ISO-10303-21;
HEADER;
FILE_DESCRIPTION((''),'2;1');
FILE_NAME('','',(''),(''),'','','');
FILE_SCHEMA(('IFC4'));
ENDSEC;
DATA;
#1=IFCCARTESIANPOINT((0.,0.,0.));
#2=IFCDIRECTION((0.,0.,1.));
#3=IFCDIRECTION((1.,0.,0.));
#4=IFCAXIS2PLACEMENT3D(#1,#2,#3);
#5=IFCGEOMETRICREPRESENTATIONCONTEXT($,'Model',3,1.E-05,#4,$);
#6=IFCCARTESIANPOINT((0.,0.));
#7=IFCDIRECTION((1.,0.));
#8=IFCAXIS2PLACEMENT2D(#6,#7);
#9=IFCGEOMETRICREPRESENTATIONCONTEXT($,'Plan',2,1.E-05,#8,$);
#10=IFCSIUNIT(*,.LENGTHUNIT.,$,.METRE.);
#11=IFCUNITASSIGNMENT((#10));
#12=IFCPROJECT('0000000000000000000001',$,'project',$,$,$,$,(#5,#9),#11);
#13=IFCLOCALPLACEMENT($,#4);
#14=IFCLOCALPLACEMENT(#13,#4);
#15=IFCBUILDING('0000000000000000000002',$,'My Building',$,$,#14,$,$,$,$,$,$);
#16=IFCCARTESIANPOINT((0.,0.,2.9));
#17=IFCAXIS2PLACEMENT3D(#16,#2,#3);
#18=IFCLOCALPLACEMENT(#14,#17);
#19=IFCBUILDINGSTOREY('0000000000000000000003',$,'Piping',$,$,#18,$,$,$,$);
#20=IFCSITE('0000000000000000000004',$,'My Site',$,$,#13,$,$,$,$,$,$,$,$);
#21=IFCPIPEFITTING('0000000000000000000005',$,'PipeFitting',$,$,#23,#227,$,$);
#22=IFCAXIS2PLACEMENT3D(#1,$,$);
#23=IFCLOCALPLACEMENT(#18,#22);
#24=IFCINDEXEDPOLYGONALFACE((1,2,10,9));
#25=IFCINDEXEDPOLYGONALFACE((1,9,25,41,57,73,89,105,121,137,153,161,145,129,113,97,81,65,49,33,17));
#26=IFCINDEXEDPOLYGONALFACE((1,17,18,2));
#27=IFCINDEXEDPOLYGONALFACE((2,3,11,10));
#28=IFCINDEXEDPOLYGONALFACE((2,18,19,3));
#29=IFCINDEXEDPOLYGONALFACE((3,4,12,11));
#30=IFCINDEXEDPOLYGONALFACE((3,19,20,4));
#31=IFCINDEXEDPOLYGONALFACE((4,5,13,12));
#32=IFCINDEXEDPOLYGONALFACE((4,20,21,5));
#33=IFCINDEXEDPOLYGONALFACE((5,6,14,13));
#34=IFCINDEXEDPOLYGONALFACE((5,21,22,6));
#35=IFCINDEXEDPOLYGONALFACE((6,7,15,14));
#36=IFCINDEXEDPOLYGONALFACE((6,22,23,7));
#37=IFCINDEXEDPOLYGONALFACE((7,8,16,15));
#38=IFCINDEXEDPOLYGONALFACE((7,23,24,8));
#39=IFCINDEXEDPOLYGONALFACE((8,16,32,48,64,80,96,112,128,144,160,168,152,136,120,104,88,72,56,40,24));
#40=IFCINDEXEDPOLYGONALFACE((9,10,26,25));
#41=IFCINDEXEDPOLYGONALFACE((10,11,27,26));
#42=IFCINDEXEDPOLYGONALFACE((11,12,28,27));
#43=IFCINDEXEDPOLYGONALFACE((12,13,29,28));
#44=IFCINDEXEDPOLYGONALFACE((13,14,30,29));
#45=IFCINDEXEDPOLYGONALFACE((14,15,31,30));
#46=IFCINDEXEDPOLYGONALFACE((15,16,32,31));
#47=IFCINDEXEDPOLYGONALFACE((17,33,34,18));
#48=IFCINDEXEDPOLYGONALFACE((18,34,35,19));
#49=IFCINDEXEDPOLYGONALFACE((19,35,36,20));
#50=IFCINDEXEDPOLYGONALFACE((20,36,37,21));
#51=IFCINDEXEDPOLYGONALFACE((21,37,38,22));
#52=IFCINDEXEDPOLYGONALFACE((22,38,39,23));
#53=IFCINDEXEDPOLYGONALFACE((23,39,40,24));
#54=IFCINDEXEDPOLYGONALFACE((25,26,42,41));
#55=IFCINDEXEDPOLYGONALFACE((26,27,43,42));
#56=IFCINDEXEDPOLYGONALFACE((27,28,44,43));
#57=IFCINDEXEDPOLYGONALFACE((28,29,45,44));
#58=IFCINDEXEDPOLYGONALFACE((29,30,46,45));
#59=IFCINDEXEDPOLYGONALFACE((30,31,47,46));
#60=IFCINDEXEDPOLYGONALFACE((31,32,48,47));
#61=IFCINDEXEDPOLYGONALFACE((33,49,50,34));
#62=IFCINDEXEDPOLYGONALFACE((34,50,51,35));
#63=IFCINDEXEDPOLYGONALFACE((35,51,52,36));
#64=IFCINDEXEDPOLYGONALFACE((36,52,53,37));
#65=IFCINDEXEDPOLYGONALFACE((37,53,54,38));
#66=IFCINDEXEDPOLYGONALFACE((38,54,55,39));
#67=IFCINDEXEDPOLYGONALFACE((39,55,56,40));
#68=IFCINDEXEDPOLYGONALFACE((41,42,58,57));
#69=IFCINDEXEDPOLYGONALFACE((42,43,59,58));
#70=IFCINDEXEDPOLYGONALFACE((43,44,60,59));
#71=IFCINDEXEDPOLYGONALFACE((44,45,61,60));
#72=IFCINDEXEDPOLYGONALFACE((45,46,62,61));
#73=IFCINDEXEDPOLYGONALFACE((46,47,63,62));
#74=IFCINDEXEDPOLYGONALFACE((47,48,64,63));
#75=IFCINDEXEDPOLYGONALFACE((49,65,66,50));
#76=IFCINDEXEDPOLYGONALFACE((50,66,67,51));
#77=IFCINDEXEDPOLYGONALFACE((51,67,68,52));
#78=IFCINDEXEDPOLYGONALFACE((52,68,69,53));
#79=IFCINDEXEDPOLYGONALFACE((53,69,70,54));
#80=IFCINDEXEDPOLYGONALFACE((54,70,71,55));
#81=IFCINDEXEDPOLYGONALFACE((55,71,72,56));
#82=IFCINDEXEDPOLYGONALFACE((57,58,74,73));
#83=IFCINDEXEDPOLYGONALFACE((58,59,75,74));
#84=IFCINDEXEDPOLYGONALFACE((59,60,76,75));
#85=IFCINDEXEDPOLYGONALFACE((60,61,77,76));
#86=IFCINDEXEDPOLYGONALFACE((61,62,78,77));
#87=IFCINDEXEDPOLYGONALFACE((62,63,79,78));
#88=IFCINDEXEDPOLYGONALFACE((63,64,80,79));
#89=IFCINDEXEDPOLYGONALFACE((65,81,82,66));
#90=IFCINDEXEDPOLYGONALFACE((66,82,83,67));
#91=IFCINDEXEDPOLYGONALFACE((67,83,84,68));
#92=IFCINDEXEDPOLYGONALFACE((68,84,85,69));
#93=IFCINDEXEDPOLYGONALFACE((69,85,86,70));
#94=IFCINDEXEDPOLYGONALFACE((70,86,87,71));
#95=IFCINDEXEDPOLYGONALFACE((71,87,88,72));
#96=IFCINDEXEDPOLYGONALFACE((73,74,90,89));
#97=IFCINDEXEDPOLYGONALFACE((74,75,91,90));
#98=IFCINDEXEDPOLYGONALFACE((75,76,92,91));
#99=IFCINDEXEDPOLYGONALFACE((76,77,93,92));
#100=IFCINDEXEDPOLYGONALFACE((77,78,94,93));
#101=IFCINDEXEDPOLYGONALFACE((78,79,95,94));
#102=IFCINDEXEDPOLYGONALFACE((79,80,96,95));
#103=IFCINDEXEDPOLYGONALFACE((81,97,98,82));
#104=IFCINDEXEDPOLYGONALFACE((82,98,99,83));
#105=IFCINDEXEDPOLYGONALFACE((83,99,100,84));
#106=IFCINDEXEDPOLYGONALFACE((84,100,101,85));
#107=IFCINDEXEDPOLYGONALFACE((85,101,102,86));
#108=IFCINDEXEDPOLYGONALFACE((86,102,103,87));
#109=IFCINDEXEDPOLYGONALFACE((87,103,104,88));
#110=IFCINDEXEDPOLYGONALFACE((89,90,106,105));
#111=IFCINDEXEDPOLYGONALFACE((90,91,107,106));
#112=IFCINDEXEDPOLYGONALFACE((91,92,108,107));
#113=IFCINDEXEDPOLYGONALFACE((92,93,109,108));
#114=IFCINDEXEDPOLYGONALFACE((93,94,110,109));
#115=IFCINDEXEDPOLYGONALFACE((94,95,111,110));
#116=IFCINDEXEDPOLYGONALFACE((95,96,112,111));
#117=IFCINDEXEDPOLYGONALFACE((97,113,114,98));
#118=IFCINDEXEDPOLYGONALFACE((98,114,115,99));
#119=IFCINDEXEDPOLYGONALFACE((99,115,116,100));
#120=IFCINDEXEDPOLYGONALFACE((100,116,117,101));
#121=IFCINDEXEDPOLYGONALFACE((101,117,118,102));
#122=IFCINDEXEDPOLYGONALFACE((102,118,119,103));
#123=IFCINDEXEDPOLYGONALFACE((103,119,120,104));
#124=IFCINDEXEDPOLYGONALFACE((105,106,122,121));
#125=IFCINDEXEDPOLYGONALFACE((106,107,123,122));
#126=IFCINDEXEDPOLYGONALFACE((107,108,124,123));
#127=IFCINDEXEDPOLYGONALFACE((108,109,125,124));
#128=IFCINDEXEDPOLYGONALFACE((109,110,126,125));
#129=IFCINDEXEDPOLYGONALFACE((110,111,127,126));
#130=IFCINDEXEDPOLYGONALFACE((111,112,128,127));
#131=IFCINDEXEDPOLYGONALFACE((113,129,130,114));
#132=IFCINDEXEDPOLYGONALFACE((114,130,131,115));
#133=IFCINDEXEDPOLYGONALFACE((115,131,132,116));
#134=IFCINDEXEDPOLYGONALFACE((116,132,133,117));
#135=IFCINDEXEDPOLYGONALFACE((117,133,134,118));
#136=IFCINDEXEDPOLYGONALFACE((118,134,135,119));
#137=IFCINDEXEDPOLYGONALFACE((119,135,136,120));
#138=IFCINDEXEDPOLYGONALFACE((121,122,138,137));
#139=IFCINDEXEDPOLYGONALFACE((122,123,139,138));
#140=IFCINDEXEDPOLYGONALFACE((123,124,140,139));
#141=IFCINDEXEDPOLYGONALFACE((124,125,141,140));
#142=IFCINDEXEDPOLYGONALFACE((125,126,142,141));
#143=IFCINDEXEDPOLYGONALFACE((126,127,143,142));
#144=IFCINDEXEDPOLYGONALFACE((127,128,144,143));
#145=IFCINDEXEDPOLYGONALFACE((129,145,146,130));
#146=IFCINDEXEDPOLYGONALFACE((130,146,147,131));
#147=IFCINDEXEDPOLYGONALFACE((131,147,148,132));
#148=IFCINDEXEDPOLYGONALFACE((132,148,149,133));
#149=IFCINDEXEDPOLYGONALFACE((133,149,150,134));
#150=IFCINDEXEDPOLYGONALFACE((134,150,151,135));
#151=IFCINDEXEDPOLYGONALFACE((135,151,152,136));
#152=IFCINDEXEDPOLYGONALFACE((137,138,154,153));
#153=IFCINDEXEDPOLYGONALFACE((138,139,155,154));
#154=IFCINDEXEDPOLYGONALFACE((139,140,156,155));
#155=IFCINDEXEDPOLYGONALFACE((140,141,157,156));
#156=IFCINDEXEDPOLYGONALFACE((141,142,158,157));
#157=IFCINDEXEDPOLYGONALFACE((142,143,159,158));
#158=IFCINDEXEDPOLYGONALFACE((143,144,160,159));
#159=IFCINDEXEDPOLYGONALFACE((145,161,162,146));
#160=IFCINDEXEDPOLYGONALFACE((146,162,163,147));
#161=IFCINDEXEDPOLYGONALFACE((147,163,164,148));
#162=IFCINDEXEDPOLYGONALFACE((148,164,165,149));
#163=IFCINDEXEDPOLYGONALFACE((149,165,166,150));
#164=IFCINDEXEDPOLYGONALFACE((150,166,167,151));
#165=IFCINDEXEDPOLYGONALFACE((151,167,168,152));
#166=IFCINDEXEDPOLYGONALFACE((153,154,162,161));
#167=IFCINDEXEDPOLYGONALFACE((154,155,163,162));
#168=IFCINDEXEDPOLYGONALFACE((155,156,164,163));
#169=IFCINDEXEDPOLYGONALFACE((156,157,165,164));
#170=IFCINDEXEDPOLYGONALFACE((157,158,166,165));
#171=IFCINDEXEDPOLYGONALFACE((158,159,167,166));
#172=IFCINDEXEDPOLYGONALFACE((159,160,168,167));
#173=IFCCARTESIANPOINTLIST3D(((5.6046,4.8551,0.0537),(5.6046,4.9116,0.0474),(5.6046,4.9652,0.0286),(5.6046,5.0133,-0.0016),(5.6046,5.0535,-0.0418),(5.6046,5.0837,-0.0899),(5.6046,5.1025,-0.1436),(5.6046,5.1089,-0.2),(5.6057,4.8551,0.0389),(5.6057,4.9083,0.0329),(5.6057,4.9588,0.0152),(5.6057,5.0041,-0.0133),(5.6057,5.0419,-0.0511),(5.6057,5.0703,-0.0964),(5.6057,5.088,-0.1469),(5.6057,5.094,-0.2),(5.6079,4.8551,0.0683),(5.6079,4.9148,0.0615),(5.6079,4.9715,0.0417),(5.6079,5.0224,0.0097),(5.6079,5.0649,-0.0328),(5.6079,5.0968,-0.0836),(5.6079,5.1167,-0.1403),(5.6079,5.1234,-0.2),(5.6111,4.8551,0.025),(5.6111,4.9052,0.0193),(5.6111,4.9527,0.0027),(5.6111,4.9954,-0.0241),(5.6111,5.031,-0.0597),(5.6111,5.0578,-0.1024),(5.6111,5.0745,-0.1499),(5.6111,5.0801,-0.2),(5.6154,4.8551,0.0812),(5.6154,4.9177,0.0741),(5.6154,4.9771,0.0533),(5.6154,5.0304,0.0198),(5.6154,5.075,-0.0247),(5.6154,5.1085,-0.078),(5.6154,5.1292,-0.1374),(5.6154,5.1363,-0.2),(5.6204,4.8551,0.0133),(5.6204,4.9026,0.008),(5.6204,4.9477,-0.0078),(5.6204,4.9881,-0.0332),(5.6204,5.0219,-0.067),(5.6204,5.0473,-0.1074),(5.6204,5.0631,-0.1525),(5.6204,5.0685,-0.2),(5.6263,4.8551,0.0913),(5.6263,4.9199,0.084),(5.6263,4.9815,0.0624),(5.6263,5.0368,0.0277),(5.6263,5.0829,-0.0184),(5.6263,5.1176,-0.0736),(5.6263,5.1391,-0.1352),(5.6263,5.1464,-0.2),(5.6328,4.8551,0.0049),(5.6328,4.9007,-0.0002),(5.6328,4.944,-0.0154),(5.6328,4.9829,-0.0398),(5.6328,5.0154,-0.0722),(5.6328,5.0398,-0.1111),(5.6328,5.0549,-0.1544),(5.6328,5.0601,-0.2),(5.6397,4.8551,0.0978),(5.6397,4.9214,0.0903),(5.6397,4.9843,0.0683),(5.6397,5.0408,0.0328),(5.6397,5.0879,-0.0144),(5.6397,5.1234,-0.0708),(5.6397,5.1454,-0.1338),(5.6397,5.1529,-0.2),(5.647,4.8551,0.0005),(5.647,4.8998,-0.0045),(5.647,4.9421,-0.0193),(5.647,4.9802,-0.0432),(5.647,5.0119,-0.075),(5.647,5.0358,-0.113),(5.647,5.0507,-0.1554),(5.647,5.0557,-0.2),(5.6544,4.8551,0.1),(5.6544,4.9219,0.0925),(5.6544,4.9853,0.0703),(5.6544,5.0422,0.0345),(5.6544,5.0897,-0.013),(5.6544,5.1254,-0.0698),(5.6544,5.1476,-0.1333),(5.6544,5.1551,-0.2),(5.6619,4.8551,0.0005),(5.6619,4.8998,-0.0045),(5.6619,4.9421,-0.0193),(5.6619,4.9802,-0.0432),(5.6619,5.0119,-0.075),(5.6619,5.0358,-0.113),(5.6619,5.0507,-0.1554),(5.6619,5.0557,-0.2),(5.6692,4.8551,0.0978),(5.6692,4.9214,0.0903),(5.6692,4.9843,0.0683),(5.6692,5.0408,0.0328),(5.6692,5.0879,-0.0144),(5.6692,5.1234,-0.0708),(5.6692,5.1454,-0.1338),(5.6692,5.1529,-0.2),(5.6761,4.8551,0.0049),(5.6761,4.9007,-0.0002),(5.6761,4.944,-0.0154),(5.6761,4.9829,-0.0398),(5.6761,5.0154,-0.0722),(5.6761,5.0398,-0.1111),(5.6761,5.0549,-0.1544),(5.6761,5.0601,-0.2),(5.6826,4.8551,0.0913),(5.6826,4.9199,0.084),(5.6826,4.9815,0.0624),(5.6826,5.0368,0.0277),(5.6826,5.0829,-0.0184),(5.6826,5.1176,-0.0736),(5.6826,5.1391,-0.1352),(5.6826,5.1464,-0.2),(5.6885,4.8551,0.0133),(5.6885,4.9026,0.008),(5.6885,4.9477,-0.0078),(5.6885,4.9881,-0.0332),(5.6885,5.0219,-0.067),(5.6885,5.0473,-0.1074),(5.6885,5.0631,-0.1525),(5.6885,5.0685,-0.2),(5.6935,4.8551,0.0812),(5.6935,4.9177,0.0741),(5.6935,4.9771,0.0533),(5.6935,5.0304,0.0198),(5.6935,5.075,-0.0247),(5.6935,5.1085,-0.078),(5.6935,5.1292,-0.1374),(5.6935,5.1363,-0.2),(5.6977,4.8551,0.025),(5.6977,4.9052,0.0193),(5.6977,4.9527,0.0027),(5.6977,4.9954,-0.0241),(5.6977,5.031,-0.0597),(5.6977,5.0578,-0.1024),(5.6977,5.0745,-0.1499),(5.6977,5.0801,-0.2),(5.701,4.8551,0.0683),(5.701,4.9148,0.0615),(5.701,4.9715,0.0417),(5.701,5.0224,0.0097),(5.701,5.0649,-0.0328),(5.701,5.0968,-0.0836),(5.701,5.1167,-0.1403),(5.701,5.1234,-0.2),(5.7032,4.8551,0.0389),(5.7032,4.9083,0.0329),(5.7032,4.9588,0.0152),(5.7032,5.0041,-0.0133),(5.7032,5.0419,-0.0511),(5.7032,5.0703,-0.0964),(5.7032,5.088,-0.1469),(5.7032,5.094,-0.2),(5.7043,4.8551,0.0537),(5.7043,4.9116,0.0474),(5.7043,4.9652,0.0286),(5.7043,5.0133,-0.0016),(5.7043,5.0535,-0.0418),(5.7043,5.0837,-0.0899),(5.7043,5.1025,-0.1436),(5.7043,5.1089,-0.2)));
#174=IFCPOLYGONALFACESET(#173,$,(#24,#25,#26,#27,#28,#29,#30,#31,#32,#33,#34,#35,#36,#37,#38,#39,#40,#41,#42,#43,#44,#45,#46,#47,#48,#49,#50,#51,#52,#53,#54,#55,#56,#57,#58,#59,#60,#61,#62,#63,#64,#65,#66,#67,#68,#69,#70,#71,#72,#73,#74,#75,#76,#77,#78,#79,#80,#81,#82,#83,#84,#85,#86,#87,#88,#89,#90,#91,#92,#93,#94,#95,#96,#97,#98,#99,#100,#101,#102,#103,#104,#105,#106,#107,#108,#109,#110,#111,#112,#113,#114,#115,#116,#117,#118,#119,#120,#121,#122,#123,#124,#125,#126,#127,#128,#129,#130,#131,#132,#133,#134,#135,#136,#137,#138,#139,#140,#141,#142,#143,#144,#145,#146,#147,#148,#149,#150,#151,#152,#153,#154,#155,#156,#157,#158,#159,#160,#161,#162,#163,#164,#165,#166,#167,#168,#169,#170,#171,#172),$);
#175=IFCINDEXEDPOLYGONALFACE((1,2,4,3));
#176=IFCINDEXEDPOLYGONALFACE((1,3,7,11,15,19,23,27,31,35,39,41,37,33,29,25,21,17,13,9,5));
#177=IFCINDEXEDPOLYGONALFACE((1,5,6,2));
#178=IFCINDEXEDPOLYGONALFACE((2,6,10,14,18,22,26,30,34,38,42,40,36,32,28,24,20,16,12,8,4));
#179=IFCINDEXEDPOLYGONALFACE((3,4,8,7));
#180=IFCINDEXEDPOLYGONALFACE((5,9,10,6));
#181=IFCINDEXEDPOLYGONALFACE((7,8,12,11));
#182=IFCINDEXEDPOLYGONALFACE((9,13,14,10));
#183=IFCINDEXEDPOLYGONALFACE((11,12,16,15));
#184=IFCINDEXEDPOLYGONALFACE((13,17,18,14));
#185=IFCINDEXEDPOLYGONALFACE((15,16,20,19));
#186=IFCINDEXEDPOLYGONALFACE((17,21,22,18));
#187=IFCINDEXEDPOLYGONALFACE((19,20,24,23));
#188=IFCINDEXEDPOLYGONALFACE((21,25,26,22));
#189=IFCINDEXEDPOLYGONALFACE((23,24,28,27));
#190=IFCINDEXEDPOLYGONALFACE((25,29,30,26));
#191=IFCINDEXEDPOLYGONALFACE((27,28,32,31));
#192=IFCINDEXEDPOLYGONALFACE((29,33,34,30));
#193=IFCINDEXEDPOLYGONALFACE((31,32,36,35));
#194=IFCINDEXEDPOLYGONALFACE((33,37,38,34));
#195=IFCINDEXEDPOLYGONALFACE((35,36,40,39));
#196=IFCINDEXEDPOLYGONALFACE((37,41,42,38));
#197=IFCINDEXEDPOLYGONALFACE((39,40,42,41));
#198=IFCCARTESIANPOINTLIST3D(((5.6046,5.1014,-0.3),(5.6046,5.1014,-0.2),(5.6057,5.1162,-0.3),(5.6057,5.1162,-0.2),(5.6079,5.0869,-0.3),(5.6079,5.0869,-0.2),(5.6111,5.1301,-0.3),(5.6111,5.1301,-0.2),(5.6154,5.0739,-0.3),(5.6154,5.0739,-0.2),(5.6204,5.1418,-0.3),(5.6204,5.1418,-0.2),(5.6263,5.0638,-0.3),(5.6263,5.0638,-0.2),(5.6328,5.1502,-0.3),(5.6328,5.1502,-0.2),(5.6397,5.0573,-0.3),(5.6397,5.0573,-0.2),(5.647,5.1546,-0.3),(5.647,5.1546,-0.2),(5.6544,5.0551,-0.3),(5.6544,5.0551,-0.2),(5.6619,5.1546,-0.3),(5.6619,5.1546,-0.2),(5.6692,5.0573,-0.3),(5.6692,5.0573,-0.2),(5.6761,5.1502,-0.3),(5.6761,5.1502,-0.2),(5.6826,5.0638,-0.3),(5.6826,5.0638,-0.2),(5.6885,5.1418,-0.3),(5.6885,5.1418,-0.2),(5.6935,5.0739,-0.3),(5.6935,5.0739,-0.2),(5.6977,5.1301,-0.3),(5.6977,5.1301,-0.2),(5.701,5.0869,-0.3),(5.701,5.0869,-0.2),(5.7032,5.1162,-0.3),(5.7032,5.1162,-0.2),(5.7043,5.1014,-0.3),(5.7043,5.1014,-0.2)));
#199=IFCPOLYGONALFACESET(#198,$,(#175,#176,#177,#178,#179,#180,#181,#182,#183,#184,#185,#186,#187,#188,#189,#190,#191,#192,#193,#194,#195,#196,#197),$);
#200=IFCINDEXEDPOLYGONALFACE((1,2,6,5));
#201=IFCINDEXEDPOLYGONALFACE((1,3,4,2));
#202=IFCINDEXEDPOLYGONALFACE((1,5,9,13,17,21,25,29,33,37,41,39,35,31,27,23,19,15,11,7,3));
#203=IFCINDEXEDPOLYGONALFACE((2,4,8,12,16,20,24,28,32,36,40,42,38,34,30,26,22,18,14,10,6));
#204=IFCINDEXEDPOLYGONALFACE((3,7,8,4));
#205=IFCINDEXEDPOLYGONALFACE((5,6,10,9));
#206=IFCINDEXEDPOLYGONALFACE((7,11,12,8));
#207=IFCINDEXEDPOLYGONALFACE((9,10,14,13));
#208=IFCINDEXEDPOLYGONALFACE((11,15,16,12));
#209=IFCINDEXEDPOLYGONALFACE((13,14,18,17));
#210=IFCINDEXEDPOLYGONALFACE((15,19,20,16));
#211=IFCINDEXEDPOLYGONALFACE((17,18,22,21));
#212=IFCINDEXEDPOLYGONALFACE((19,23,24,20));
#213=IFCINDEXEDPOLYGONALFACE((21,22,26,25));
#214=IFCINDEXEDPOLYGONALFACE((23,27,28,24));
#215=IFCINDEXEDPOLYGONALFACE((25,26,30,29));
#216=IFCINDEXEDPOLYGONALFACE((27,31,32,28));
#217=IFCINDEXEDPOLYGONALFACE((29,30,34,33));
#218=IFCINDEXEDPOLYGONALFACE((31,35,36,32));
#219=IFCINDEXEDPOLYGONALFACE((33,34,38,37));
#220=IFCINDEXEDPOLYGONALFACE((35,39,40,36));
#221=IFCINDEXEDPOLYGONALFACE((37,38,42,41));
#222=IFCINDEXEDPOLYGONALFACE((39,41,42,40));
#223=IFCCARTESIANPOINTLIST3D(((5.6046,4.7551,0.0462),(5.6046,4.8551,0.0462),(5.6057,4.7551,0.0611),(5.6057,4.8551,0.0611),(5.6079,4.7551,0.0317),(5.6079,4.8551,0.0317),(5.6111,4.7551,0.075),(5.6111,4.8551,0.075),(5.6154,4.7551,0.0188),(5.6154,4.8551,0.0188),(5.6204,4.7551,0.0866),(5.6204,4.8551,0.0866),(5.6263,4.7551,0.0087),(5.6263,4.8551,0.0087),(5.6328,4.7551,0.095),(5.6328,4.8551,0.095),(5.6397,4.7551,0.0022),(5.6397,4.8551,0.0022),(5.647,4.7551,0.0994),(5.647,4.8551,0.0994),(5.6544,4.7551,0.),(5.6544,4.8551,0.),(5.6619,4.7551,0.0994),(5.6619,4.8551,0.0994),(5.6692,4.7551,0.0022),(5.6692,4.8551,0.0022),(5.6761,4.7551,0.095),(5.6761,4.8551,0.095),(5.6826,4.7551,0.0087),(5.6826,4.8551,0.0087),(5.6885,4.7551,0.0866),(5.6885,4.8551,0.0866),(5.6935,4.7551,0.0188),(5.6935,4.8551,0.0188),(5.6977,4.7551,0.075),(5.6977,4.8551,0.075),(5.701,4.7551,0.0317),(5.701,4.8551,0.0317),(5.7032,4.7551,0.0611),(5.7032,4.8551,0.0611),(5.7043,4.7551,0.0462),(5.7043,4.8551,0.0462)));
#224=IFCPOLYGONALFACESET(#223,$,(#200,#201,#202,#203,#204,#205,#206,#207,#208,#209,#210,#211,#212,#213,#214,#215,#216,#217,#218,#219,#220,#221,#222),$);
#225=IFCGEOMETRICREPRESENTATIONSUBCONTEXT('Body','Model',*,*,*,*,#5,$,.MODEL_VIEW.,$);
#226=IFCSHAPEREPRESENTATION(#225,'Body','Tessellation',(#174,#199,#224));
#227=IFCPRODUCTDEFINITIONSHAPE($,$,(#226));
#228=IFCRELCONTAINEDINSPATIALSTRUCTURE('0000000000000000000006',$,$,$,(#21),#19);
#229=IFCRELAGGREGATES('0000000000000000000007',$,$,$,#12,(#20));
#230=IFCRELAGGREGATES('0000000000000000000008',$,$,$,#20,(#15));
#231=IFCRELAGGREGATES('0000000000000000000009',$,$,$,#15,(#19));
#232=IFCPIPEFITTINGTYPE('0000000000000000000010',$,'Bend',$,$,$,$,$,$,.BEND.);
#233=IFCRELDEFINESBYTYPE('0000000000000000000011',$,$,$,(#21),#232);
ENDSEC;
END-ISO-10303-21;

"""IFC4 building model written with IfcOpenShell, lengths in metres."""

from ifc_helpers import new_model, entity, si_unit, frame, origin_with_axes, origin_2d_with_axis, place, context, subcontext, project, spatial, circle, extrude, source, transform, mapped, type_object, type_shapes, element, save


model = new_model("IFC4")

# Units and contexts
model_context = context("Model", 3, precision=1e-05, world=origin_with_axes())
plan_context = context("Plan", 2, precision=1e-05, world=origin_2d_with_axis())
body_context = subcontext(model_context, "Body", "Model", "MODEL_VIEW")
ifc_project = project(units=[si_unit("LENGTHUNIT", "METRE")], contexts=[model_context, plan_context])

# Site, building, storey
site_placement = place(None, origin_with_axes())
site = spatial("IfcSite", under=ifc_project, at=site_placement, Name="My Site")
building_placement = place(site_placement, origin_with_axes())
building = spatial("IfcBuilding", under=site, at=building_placement, Name="My Building")
storey_placement = place(building_placement, frame((0.0, 0.0, 2.9), z_axis=(0.0, 0.0, 1.0), x_axis=(1.0, 0.0, 0.0)))
storey = spatial("IfcBuildingStorey", under=building, at=storey_placement, Name="Piping")

# Pipe fitting
pipe_fitting_type_1 = type_object("IfcPipeFittingType", Name="Bend", PredefinedType="BEND")
shared_shape = source(origin_with_axes(), body_context, "Body", "SolidModel", [
    entity("IfcSweptDiskSolid", entity("IfcIndexedPolyCurve", entity("IfcCartesianPointList3D", [[0.0, 0.0, -0.1], [0.0732, 0.0, -0.2768], [0.25, 0.0, -0.35]]), [entity("IfcArcIndex", [1, 2, 3])]), 0.05),
    extrude(circle(Radius=0.05), origin_with_axes(), (0.0, 0.0, -1.0), 0.1),
    extrude(circle(Radius=0.05), frame((0.25, 0.0, -0.35), z_axis=(1.0, 0.0, 0.0), x_axis=(0.0, 0.0, 1.0)), (0.0, 0.0, 1.0), 0.1),
])
type_shapes(pipe_fitting_type_1, [shared_shape])
for number, where, z_axis, x_axis, name in (
    (1, (5.6544, 5.1051, -0.3), (0.0, 0.0, -1.0), (0.0, -1.0, 0.0), "PipeFitting"),
):
    element("IfcPipeFitting", number, at=place(storey_placement, frame(where, z_axis=z_axis, x_axis=x_axis)), inside=storey, type_object=pipe_fitting_type_1, Name=name, context=body_context, shape_type="MappedRepresentation", body=[
        mapped(shared_shape, transform((0.0, 0.0, 0.0), x_axis=(1.0, 0.0, 0.0), y_axis=(0.0, 1.0, 0.0), z_axis=(0.0, 0.0, 1.0), scale=1.0)),
    ])

save(model, "model.ifc")
